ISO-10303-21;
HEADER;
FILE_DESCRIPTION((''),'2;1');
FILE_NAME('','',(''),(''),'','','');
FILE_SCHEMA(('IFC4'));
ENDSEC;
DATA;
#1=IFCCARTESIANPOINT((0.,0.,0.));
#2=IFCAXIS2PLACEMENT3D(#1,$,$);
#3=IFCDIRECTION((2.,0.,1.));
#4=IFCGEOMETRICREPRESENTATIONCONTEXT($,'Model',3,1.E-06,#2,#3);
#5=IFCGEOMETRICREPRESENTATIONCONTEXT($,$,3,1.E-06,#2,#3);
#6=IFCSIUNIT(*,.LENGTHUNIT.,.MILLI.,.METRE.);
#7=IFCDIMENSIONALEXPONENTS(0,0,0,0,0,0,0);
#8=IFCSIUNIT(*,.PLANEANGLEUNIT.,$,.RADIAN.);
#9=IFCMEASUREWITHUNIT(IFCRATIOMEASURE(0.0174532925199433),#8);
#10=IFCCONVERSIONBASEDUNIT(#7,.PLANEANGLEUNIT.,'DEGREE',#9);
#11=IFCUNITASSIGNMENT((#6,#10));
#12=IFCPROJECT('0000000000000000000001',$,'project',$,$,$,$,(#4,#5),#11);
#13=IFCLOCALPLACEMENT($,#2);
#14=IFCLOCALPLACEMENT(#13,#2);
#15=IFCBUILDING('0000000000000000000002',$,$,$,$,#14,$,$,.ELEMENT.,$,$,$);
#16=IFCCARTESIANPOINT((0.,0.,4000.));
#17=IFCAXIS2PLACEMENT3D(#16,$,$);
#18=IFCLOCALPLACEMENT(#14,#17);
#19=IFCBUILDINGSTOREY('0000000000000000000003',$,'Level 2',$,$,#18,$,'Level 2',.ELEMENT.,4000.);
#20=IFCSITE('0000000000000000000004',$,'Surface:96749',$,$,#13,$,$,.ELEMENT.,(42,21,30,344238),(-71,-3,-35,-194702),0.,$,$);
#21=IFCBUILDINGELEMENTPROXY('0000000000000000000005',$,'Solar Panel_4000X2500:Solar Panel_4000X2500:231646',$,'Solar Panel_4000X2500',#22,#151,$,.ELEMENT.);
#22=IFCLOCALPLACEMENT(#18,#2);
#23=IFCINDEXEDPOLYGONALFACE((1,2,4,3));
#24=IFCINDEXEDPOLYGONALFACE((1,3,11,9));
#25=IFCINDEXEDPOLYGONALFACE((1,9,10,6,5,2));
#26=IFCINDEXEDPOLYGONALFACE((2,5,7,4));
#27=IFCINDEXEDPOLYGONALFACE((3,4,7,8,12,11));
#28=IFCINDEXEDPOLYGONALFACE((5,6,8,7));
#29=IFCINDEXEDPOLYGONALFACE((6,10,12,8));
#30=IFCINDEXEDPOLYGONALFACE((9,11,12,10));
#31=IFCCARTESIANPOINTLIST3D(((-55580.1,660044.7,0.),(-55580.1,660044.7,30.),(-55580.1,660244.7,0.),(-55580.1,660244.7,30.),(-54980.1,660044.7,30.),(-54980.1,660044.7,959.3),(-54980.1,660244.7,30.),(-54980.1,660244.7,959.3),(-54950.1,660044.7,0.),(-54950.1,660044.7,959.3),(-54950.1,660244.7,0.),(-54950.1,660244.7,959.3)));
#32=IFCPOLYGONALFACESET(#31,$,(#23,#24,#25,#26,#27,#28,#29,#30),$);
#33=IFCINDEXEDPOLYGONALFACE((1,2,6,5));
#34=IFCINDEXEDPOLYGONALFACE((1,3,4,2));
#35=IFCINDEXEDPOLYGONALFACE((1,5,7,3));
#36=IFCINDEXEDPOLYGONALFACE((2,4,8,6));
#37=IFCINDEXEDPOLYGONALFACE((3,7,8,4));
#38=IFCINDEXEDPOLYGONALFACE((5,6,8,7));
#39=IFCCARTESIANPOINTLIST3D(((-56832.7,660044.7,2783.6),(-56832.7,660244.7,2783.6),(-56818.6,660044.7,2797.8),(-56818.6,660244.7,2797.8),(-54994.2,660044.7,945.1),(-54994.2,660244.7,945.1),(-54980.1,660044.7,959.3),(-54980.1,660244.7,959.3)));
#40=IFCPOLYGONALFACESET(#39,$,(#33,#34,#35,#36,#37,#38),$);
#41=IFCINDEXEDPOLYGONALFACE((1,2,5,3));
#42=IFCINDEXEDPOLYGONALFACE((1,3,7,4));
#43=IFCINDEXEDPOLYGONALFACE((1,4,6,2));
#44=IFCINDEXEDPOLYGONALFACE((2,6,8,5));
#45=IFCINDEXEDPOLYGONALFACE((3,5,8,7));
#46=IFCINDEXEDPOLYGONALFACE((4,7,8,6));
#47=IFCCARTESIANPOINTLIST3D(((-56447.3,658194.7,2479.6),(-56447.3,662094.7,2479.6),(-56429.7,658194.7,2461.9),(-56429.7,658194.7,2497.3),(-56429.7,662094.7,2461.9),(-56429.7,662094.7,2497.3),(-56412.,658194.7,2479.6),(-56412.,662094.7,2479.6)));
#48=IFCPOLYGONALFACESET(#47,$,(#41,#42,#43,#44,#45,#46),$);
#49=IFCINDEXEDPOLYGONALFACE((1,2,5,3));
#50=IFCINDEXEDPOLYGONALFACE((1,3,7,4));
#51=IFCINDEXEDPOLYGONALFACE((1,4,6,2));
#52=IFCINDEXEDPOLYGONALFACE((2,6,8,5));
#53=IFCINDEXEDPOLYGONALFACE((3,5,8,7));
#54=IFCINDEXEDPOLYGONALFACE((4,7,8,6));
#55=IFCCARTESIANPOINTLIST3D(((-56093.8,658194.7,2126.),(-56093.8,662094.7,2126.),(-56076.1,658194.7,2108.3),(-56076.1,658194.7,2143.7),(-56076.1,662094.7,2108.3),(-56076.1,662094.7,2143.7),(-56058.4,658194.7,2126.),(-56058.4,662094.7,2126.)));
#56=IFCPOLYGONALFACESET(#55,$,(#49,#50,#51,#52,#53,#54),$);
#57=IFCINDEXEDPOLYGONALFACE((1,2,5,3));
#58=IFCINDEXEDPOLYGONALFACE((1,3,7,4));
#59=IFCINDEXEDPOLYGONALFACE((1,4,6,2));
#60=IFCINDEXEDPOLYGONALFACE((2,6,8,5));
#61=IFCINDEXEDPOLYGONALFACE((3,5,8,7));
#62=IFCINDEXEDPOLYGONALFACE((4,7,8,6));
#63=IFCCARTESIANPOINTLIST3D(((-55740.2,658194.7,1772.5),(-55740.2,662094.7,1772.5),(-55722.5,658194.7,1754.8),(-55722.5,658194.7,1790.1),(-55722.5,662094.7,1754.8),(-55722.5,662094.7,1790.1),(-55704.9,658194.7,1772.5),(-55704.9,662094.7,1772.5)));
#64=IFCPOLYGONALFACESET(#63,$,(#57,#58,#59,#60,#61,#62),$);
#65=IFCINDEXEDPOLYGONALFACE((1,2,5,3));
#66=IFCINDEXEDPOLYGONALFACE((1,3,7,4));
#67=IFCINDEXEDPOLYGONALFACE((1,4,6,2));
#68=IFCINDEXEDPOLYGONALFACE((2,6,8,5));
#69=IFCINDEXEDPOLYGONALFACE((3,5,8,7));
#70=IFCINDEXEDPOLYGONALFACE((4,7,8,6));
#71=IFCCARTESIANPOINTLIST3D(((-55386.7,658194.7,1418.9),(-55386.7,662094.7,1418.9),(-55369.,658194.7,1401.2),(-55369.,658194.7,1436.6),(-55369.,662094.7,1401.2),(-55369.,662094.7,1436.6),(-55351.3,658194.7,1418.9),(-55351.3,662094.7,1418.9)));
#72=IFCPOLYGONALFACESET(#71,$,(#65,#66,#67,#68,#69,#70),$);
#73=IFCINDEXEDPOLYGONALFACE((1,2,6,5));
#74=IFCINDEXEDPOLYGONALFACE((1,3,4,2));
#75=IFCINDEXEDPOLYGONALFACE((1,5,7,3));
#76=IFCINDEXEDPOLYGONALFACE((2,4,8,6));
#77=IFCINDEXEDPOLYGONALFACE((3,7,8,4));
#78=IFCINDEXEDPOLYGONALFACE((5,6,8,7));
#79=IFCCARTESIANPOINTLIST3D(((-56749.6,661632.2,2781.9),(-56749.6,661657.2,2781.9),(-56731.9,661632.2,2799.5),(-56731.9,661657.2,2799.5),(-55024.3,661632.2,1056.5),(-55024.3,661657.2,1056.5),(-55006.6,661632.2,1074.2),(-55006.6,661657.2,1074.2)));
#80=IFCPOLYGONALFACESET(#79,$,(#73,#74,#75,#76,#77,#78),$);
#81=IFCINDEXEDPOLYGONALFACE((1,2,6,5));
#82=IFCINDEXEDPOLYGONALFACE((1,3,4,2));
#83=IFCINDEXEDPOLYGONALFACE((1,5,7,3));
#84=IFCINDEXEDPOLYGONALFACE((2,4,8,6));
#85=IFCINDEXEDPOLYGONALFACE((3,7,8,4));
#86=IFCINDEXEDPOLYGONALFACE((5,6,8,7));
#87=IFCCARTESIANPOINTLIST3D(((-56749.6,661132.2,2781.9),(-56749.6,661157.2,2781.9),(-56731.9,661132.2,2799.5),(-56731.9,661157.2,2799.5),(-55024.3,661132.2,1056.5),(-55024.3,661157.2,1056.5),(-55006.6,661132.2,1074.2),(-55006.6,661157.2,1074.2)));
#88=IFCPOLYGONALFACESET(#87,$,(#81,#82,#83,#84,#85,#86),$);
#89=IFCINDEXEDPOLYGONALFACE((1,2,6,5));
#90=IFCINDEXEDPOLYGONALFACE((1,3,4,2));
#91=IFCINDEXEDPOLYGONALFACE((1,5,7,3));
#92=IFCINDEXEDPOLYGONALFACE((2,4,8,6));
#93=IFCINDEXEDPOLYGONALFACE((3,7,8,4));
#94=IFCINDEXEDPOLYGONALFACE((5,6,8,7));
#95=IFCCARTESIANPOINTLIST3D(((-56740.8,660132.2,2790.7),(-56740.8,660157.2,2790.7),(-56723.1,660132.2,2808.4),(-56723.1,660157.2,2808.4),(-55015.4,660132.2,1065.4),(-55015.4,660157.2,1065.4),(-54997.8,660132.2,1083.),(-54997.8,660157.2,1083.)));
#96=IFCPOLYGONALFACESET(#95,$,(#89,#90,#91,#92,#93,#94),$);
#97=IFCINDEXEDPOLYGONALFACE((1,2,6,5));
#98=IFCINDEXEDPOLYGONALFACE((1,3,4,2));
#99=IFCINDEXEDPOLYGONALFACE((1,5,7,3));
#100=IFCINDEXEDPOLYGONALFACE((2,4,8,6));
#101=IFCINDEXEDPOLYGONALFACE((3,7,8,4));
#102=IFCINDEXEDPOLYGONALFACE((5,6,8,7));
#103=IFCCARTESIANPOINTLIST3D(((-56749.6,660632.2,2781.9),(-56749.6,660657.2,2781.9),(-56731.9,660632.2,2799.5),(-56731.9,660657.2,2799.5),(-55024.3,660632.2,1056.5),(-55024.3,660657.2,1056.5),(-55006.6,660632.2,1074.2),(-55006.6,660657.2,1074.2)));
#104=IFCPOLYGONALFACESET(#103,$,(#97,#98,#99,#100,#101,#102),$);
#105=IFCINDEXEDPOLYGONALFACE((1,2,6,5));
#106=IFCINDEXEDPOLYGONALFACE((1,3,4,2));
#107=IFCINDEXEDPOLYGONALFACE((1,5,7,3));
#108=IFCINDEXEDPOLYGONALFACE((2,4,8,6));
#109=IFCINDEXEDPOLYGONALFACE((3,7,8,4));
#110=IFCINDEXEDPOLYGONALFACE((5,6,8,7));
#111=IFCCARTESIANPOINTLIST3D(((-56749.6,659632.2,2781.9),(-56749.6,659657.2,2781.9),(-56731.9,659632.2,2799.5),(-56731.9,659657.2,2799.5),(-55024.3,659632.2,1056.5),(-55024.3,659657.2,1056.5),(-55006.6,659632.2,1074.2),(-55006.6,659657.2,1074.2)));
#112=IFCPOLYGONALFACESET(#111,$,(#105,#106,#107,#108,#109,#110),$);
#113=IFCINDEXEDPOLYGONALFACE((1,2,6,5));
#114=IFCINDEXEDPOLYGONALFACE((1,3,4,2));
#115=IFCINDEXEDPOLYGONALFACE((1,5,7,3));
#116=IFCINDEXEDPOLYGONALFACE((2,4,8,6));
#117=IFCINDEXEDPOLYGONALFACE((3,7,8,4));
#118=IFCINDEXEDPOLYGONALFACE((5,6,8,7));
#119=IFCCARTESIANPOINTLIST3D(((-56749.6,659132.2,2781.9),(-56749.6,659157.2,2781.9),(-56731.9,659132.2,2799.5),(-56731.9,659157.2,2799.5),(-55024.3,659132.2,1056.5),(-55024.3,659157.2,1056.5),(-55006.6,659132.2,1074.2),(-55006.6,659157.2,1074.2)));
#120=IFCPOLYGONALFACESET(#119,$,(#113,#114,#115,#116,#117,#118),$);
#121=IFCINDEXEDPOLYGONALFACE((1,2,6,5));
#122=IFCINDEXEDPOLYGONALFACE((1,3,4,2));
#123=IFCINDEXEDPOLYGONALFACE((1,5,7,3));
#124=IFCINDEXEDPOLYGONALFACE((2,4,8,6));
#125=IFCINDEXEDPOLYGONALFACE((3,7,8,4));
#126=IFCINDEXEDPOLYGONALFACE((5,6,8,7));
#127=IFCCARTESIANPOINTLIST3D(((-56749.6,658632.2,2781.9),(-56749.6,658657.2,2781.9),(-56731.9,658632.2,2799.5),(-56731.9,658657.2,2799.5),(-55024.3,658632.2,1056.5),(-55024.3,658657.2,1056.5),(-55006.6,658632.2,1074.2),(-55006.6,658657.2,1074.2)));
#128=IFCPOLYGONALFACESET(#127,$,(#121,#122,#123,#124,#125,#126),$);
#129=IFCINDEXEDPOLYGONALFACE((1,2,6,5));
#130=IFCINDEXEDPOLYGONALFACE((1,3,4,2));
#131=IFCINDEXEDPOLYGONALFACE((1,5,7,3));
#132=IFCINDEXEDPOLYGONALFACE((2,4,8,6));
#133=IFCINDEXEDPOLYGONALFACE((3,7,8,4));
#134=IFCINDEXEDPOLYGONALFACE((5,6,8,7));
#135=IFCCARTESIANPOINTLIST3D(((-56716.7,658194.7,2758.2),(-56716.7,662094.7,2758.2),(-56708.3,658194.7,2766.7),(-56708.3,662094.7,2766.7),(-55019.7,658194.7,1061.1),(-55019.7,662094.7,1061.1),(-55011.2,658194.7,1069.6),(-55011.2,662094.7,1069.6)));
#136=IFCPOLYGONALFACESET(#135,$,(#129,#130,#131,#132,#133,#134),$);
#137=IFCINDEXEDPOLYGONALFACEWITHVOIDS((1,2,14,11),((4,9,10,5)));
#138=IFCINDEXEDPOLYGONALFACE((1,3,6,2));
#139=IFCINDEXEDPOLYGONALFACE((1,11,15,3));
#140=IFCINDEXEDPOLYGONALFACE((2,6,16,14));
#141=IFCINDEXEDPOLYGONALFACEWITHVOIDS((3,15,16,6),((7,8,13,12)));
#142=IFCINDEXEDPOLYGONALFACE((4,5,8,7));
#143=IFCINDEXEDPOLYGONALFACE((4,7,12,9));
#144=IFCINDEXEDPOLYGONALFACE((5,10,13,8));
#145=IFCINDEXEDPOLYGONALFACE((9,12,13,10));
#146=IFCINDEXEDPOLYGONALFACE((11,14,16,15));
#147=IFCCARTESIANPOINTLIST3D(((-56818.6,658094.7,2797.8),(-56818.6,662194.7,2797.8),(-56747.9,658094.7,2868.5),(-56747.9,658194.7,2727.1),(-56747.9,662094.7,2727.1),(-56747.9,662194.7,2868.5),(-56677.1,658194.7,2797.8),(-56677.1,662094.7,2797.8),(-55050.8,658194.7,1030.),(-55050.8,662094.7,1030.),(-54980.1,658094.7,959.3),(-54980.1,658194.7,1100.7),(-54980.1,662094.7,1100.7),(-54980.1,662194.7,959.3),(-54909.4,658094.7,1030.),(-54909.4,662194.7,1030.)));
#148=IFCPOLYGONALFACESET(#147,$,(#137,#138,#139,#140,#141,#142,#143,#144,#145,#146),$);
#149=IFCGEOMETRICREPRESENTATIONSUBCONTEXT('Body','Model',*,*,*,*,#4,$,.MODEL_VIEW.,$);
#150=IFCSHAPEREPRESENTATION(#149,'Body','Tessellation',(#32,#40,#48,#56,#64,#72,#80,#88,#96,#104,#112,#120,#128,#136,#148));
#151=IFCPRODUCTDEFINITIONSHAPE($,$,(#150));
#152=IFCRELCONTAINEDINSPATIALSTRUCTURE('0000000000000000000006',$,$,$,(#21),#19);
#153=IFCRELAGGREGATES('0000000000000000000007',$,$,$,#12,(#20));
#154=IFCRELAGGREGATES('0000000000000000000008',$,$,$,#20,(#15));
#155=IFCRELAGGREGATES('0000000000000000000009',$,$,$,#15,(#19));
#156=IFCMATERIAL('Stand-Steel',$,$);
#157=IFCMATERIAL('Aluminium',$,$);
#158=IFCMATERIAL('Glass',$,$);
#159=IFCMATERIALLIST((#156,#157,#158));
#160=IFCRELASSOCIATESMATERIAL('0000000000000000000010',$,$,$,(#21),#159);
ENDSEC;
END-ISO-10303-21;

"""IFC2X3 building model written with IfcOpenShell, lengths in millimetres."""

from ifc_helpers import new_model, entity, si_unit, converted_unit, direction, frame, frame_2d, origin, origin_2d_with_axis, place, context, subcontext, project, spatial, polyline, rectangle, outline, extrude, source, transform, mapped, material, material_list, element, save


model = new_model("IFC2X3")

# Units and contexts
model_context = context("Model", 3, precision=1e-06, world=origin(), true_north=direction((2.0, 0.0, 1.0)))
context_of_model = context(None, 3, precision=1e-06, world=origin(), true_north=direction((2.0, 0.0, 1.0)))
body_context = subcontext(model_context, "Body", "Model", "MODEL_VIEW")
ifc_project = project(units=[si_unit("LENGTHUNIT", "METRE", prefix="MILLI"), converted_unit("PLANEANGLEUNIT", "DEGREE", entity("IfcRatioMeasure", 0.0174532925199433), si_unit("PLANEANGLEUNIT", "RADIAN"), dimensions=[0, 0, 0, 0, 0, 0, 0])], contexts=[model_context, context_of_model])

# Site, building, storey
site_placement = place(None, origin())
site = spatial("IfcSite", under=ifc_project, at=site_placement, Name="Surface:96749", CompositionType="ELEMENT", RefLatitude=(42, 21, 30, 344238), RefLongitude=(-71, -3, -35, -194702), RefElevation=0.0)
building_placement = place(site_placement, origin())
building = spatial("IfcBuilding", under=site, at=building_placement, CompositionType="ELEMENT")
storey_placement = place(building_placement, frame((0.0, 0.0, 4000.0)))
storey = spatial("IfcBuildingStorey", under=building, at=storey_placement, Name="Level 2", LongName="Level 2", CompositionType="ELEMENT", Elevation=4000.0)

# Building element proxy
ifc_material_1 = material(Name="Stand-Steel")
ifc_material_2 = material(Name="Aluminium")
ifc_material_3 = material(Name="Glass")
shared_shape = source(origin(), body_context, "Body", "SweptSolid", [
    extrude(outline(polyline([(-629.5, -220.0), (329.8, -220.0), (329.8, 410.0), (299.8, 410.0), (299.8, -190.0), (-629.5, -190.0), (-629.5, -220.0)])), frame((-190.0, -100.0, 299.8), z_axis=(0.0, 1.0, 0.0), x_axis=(0.0, 0.0, -1.0)), (0.0, 0.0, 1.0), 200.0),
    extrude(rectangle(XDim=20.0, YDim=200.0, at=frame_2d((0.0, 0.0), x_axis=(0.0, 1.0))), frame((-7.1, 0.0, 922.2), z_axis=(-0.707107, 0.0, 0.707107), x_axis=(0.0, 1.0, 0.0)), (0.0, 0.0, 1.0), 2600.0),
    extrude(rectangle(XDim=25.0, YDim=25.0, at=frame_2d((0.0, 0.0), x_axis=(1.0, 0.0))), frame((-1449.6, -1950.0, 2449.6), z_axis=(0.0, 1.0, 0.0), x_axis=(-0.707107, 0.0, -0.707107)), (0.0, 0.0, 1.0), 3900.0),
    extrude(rectangle(XDim=25.0, YDim=25.0, at=origin_2d_with_axis()), frame((-1096.0, -1950.0, 2096.0), z_axis=(0.0, 1.0, 0.0), x_axis=(-0.707107, 0.0, -0.707107)), (0.0, 0.0, 1.0), 3900.0),
    extrude(rectangle(XDim=25.0, YDim=25.0, at=origin_2d_with_axis()), frame((-742.5, -1950.0, 1742.5), z_axis=(0.0, 1.0, 0.0), x_axis=(-0.707107, 0.0, -0.707107)), (0.0, 0.0, 1.0), 3900.0),
    extrude(rectangle(XDim=25.0, YDim=25.0, at=frame_2d((0.0, 0.0), x_axis=(1.0, 0.0))), frame((-388.9, -1950.0, 1388.9), z_axis=(0.0, 1.0, 0.0), x_axis=(-0.707107, 0.0, -0.707107)), (0.0, 0.0, 1.0), 3900.0),
    extrude(rectangle(XDim=25.0, YDim=25.0, at=frame_2d((0.0, 0.0), x_axis=(0.0, 1.0))), frame((-35.4, 1500.0, 1035.4), z_axis=(-0.707107, 0.0, 0.707107), x_axis=(0.0, 1.0, 0.0)), (0.0, 0.0, 1.0), 2440.0),
    extrude(rectangle(XDim=25.0, YDim=25.0, at=frame_2d((0.0, 0.0), x_axis=(0.0, 1.0))), frame((-35.4, 1000.0, 1035.4), z_axis=(-0.707107, 0.0, 0.707107), x_axis=(0.0, 1.0, 0.0)), (0.0, 0.0, 1.0), 2440.0),
    extrude(rectangle(XDim=25.0, YDim=25.0, at=frame_2d((0.0, 0.0), x_axis=(0.0, 1.0))), frame((-26.5, 0.0, 1044.2), z_axis=(-0.707107, 0.0, 0.707107), x_axis=(0.0, -1.0, 0.0)), (0.0, 0.0, 1.0), 2440.0),
    extrude(rectangle(XDim=25.0, YDim=25.0, at=frame_2d((0.0, 0.0), x_axis=(0.0, 1.0))), frame((-35.4, 500.0, 1035.4), z_axis=(-0.707107, 0.0, 0.707107), x_axis=(0.0, 1.0, 0.0)), (0.0, 0.0, 1.0), 2440.0),
    extrude(rectangle(XDim=25.0, YDim=25.0, at=frame_2d((0.0, 0.0), x_axis=(0.0, 1.0))), frame((-35.4, -500.0, 1035.4), z_axis=(-0.707107, 0.0, 0.707107), x_axis=(0.0, 1.0, 0.0)), (0.0, 0.0, 1.0), 2440.0),
    extrude(rectangle(XDim=25.0, YDim=25.0, at=frame_2d((0.0, 0.0), x_axis=(0.0, 1.0))), frame((-35.4, -1000.0, 1035.4), z_axis=(-0.707107, 0.0, 0.707107), x_axis=(0.0, 1.0, 0.0)), (0.0, 0.0, 1.0), 2440.0),
    extrude(rectangle(XDim=25.0, YDim=25.0, at=frame_2d((0.0, 0.0), x_axis=(0.0, 1.0))), frame((-35.4, -1500.0, 1035.4), z_axis=(-0.707107, 0.0, 0.707107), x_axis=(0.0, 1.0, 0.0)), (0.0, 0.0, 1.0), 2440.0),
    extrude(rectangle(XDim=2400.0, YDim=12.0, at=frame_2d((0.0, 0.0), x_axis=(1.0, 0.0))), frame((-883.9, -1950.0, 1883.9), z_axis=(0.0, 1.0, 0.0), x_axis=(0.707107, 0.0, -0.707107)), (0.0, 0.0, 1.0), 3900.0),
    extrude(outline(polyline([(-2050.0, -1300.0), (2050.0, -1300.0), (2050.0, 1300.0), (-2050.0, 1300.0), (-2050.0, -1300.0)]), holes=[polyline([(1950.0, -1200.0), (-1950.0, -1200.0), (-1950.0, 1200.0), (1950.0, 1200.0), (1950.0, -1200.0)])]), frame((-919.2, 0.0, 1848.5), z_axis=(0.707107, 0.0, 0.707107), x_axis=(0.0, 1.0, 0.0)), (0.0, 0.0, 1.0), 100.0),
])
ifc_material_list_1 = material_list([ifc_material_1, ifc_material_2, ifc_material_3])
proxy_1_placement = place(storey_placement, frame((-54980.1, 660144.7, 30.0)))
element("IfcBuildingElementProxy", 1, at=proxy_1_placement, inside=storey, material=ifc_material_list_1, Name="Solar Panel_4000X2500:Solar Panel_4000X2500:231646", ObjectType="Solar Panel_4000X2500", CompositionType="ELEMENT", context=body_context, shape_type="MappedRepresentation", body=[
    mapped(shared_shape, transform((0.0, 0.0, 0.0), scale=1.0)),
])

save(model, "model.ifc")
